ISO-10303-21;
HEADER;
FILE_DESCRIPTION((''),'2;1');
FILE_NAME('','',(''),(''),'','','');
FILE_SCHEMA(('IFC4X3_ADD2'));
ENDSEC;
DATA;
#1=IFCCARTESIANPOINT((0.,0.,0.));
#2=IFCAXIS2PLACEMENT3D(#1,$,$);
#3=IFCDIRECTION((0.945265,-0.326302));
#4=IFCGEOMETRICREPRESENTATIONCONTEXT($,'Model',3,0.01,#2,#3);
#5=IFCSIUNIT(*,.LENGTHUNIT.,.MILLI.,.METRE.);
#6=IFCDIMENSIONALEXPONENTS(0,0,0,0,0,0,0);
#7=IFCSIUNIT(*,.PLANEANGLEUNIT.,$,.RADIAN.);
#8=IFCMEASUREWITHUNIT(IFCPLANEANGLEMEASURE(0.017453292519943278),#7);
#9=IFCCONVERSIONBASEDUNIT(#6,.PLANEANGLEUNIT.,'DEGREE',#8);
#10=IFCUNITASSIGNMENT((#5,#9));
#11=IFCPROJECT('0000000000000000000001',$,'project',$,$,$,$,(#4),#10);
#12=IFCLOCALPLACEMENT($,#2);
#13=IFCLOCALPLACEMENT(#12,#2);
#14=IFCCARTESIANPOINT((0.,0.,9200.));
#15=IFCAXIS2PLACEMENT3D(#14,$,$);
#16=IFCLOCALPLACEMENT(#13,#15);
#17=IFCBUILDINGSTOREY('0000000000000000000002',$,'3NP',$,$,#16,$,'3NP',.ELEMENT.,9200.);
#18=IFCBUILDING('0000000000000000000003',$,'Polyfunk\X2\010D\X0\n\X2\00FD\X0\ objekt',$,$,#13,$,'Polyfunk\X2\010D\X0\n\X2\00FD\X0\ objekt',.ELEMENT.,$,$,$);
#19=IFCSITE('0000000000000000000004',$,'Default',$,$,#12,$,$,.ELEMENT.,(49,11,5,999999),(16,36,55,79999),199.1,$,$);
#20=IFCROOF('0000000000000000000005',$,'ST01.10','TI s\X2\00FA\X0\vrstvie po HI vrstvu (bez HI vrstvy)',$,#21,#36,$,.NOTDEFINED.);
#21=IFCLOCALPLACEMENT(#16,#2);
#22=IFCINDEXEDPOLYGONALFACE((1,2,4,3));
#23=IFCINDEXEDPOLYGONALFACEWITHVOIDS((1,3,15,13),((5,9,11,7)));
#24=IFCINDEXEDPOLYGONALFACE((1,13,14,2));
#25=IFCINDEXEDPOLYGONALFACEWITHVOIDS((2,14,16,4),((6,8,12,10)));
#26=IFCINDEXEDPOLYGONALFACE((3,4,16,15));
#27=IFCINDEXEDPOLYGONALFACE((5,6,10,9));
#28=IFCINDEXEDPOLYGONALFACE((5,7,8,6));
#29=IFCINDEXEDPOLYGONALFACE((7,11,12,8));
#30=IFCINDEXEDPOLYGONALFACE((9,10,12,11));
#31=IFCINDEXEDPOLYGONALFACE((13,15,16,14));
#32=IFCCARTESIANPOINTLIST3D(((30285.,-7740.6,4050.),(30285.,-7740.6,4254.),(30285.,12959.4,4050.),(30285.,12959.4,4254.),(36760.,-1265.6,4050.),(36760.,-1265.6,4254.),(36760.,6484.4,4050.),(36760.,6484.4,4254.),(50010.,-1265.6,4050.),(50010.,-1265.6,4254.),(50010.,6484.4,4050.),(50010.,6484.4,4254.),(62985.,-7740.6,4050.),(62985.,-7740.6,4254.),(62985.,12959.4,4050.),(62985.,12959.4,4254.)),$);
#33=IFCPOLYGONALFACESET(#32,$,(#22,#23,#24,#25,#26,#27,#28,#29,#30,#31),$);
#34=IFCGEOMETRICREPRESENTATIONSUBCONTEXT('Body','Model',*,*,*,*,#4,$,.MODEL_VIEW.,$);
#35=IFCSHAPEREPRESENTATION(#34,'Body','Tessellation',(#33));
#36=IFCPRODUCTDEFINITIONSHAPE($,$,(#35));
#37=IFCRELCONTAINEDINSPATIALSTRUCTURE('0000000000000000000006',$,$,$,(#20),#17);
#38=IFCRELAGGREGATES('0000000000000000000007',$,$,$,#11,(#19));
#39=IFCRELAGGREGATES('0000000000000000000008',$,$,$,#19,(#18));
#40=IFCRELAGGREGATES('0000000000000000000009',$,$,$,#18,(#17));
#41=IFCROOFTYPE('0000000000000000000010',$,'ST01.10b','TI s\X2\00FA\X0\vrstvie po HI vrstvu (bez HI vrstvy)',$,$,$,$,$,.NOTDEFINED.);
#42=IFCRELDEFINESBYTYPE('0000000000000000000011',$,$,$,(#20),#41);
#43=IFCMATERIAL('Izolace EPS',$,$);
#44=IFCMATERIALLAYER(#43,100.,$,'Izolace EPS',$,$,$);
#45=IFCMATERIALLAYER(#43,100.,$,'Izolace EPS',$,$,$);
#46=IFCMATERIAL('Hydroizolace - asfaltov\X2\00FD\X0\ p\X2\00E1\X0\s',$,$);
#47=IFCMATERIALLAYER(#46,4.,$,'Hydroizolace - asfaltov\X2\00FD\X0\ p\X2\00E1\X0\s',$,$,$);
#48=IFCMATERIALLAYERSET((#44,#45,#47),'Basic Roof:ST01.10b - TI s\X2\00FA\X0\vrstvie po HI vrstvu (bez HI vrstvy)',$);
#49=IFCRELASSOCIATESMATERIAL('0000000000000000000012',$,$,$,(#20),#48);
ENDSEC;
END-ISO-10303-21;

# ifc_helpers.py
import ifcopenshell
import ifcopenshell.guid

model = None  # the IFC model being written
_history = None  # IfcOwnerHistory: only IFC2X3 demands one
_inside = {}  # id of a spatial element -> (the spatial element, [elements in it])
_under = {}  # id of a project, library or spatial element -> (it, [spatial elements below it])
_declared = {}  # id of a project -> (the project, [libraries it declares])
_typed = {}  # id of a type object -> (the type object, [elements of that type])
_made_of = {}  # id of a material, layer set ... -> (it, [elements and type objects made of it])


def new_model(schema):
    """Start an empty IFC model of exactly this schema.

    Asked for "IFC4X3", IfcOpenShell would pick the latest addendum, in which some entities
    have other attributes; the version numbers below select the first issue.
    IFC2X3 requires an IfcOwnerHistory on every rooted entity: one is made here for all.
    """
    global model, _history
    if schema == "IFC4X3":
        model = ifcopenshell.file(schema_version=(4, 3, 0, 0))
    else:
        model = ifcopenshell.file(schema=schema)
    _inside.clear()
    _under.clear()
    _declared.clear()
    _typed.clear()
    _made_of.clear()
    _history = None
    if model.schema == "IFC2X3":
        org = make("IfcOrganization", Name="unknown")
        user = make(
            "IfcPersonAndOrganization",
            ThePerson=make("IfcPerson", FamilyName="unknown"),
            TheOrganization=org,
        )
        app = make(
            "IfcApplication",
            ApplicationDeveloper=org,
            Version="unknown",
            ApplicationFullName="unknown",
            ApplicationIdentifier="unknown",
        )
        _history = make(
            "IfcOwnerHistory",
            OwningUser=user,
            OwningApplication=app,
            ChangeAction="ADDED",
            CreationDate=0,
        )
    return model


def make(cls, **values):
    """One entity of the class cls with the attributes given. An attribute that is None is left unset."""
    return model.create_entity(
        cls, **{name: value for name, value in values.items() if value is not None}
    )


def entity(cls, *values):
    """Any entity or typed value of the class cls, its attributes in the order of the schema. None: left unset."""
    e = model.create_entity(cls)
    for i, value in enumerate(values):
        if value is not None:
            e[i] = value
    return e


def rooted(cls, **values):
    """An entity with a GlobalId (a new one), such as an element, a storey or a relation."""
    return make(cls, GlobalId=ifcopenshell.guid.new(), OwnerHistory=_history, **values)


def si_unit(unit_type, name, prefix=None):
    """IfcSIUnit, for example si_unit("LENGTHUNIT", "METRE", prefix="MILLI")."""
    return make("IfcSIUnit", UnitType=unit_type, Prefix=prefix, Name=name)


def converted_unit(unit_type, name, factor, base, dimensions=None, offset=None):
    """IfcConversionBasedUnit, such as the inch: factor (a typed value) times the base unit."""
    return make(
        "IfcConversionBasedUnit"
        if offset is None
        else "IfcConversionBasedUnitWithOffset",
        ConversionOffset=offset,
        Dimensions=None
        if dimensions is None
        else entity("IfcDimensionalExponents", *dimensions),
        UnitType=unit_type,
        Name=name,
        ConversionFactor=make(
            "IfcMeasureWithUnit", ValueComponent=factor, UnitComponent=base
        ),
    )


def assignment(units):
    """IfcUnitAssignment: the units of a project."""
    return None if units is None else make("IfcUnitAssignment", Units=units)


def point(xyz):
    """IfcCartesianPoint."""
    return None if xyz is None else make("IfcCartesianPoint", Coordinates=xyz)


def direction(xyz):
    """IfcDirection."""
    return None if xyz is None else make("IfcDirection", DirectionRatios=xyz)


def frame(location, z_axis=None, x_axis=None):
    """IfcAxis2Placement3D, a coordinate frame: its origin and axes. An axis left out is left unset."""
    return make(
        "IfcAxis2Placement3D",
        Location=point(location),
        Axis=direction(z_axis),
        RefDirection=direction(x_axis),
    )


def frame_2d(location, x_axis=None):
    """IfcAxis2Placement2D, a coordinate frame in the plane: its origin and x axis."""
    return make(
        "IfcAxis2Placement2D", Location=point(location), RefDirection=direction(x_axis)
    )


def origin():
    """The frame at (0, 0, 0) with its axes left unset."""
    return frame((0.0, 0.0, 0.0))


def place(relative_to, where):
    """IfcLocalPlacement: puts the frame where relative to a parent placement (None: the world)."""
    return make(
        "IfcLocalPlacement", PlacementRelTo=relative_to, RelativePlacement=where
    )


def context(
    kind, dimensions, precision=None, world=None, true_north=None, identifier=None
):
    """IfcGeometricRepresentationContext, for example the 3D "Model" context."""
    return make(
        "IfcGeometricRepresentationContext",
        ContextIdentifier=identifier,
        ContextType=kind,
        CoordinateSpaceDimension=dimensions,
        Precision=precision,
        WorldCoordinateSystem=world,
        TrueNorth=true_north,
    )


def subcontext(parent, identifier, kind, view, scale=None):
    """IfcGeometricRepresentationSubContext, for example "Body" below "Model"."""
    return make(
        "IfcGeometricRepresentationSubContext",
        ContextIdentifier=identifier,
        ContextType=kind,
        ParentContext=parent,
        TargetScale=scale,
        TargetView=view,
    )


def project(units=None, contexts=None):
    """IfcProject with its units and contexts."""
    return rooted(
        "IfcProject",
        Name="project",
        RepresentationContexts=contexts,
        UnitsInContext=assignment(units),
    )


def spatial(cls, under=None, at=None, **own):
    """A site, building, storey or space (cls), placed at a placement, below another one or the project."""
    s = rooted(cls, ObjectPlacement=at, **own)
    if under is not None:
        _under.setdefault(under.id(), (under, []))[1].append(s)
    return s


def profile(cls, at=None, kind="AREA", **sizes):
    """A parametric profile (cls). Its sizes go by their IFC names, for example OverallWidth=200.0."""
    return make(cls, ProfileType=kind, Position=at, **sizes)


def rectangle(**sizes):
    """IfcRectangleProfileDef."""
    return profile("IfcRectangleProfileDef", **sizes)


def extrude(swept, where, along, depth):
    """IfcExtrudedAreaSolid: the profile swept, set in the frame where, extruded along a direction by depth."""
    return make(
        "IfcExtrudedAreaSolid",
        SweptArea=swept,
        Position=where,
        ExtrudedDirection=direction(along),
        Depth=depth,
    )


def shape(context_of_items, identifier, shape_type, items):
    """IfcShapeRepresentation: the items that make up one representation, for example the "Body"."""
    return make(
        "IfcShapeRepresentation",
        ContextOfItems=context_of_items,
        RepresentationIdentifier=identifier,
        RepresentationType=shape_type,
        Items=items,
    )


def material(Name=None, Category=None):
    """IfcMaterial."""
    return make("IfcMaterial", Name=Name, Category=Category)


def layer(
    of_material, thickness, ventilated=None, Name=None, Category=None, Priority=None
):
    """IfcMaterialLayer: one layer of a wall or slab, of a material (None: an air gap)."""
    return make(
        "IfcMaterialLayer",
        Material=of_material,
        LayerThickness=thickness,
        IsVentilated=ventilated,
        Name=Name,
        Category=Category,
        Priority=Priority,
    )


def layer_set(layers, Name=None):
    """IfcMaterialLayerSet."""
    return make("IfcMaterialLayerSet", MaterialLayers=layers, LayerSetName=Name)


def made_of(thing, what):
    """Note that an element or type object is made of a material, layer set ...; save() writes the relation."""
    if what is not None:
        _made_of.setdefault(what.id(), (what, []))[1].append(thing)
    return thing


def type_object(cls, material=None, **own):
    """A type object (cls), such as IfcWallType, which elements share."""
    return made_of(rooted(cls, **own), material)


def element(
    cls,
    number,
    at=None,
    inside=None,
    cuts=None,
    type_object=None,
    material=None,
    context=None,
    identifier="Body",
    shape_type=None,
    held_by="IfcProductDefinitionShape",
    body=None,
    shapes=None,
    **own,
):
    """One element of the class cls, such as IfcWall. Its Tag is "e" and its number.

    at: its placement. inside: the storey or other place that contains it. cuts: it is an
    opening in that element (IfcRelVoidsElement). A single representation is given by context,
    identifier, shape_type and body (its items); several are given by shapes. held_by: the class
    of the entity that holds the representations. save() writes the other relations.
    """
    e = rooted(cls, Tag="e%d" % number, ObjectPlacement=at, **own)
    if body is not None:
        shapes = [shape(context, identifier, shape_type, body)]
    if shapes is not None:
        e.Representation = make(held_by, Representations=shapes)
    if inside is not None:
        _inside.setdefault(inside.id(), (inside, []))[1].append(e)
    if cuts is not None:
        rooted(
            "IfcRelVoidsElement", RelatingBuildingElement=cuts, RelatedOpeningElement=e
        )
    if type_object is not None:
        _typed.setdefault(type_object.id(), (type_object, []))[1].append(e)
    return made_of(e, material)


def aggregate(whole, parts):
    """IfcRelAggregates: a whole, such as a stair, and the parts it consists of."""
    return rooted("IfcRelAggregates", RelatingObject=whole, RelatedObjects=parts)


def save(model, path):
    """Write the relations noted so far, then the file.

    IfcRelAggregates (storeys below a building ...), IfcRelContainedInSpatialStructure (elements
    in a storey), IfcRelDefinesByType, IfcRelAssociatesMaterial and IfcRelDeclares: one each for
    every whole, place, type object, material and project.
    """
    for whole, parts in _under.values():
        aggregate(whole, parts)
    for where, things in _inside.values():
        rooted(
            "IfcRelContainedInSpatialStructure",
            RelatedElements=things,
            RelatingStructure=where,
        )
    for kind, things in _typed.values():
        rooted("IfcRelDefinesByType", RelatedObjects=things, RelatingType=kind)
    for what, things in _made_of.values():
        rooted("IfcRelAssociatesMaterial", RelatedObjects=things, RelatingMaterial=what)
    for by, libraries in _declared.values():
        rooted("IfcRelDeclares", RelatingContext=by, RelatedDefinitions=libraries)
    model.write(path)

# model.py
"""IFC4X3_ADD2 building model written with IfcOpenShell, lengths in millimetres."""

from ifc_helpers import new_model, entity, si_unit, converted_unit, direction, frame, frame_2d, origin, place, context, subcontext, project, spatial, rectangle, extrude, material, layer, layer_set, type_object, element, save


model = new_model("IFC4X3_ADD2")

# Units and contexts
model_context = context("Model", 3, precision=0.01, world=origin(), true_north=direction((0.945265, -0.326302)))
body_context = subcontext(model_context, "Body", "Model", "MODEL_VIEW")
ifc_project = project(units=[si_unit("LENGTHUNIT", "METRE", prefix="MILLI"), converted_unit("PLANEANGLEUNIT", "DEGREE", entity("IfcPlaneAngleMeasure", 0.017453292519943278), si_unit("PLANEANGLEUNIT", "RADIAN"), dimensions=[0, 0, 0, 0, 0, 0, 0])], contexts=[model_context])

# Site, building, storey
site_placement = place(None, origin())
site = spatial("IfcSite", under=ifc_project, at=site_placement, Name="Default", CompositionType="ELEMENT", RefLatitude=(49, 11, 5, 999999), RefLongitude=(16, 36, 55, 79999), RefElevation=199.1)
building_placement = place(site_placement, origin())
building = spatial("IfcBuilding", under=site, at=building_placement, Name="Polyfunkčný objekt", LongName="Polyfunkčný objekt", CompositionType="ELEMENT")
storey_placement = place(building_placement, frame((0.0, 0.0, 9200.0)))
storey = spatial("IfcBuildingStorey", under=building, at=storey_placement, Name="3NP", LongName="3NP", CompositionType="ELEMENT", Elevation=9200.0)

# Roof, opening
ifc_material_1 = material(Name="Izolace EPS")
ifc_layer_1 = layer(ifc_material_1, 100.0, Name="Izolace EPS")
ifc_layer_2 = layer(ifc_material_1, 100.0, Name="Izolace EPS")
ifc_material_2 = material(Name="Hydroizolace - asfaltový pás")
ifc_layer_3 = layer(ifc_material_2, 4.0, Name="Hydroizolace - asfaltový pás")
ifc_layer_set_1 = layer_set([ifc_layer_1, ifc_layer_2, ifc_layer_3], Name="Basic Roof:ST01.10b - TI súvrstvie po HI vrstvu (bez HI vrstvy)")
roof_type = type_object("IfcRoofType", Name="ST01.10b", Description="TI súvrstvie po HI vrstvu (bez HI vrstvy)", PredefinedType="NOTDEFINED")
roof_placement = place(storey_placement, frame((30285.0, -7740.6, 4050.0)))
roof = element("IfcRoof", 1, at=roof_placement, inside=storey, type_object=roof_type, material=ifc_layer_set_1, Name="ST01.10", Description="TI súvrstvie po HI vrstvu (bez HI vrstvy)", PredefinedType="NOTDEFINED", context=body_context, shape_type="SweptSolid", body=[
    extrude(rectangle(XDim=20700.0, YDim=32700.0, at=frame_2d((0.0, 0.0), x_axis=(1.0, 0.0))), frame((16350.0, 10350.0, 0.0), z_axis=(0.0, 0.0, 1.0), x_axis=(0.0, -1.0, 0.0)), (0.0, 0.0, 1.0), 204.0),
])
opening_placement = place(storey_placement, frame((30285.0, -7740.6, 4050.0)))
element("IfcOpeningElement", 2, at=opening_placement, cuts=roof, PredefinedType="OPENING", context=body_context, shape_type="SweptSolid", body=[
    extrude(rectangle(XDim=7750.0, YDim=13250.0, at=frame_2d((-31.2, 31.2), x_axis=(1.0, 0.0))), frame((13131.3, 10381.2, 0.0), z_axis=(0.0, 0.0, 1.0), x_axis=(0.0, 1.0, 0.0)), (0.0, 0.0, 1.0), 204.0),
])

save(model, "model.ifc")
